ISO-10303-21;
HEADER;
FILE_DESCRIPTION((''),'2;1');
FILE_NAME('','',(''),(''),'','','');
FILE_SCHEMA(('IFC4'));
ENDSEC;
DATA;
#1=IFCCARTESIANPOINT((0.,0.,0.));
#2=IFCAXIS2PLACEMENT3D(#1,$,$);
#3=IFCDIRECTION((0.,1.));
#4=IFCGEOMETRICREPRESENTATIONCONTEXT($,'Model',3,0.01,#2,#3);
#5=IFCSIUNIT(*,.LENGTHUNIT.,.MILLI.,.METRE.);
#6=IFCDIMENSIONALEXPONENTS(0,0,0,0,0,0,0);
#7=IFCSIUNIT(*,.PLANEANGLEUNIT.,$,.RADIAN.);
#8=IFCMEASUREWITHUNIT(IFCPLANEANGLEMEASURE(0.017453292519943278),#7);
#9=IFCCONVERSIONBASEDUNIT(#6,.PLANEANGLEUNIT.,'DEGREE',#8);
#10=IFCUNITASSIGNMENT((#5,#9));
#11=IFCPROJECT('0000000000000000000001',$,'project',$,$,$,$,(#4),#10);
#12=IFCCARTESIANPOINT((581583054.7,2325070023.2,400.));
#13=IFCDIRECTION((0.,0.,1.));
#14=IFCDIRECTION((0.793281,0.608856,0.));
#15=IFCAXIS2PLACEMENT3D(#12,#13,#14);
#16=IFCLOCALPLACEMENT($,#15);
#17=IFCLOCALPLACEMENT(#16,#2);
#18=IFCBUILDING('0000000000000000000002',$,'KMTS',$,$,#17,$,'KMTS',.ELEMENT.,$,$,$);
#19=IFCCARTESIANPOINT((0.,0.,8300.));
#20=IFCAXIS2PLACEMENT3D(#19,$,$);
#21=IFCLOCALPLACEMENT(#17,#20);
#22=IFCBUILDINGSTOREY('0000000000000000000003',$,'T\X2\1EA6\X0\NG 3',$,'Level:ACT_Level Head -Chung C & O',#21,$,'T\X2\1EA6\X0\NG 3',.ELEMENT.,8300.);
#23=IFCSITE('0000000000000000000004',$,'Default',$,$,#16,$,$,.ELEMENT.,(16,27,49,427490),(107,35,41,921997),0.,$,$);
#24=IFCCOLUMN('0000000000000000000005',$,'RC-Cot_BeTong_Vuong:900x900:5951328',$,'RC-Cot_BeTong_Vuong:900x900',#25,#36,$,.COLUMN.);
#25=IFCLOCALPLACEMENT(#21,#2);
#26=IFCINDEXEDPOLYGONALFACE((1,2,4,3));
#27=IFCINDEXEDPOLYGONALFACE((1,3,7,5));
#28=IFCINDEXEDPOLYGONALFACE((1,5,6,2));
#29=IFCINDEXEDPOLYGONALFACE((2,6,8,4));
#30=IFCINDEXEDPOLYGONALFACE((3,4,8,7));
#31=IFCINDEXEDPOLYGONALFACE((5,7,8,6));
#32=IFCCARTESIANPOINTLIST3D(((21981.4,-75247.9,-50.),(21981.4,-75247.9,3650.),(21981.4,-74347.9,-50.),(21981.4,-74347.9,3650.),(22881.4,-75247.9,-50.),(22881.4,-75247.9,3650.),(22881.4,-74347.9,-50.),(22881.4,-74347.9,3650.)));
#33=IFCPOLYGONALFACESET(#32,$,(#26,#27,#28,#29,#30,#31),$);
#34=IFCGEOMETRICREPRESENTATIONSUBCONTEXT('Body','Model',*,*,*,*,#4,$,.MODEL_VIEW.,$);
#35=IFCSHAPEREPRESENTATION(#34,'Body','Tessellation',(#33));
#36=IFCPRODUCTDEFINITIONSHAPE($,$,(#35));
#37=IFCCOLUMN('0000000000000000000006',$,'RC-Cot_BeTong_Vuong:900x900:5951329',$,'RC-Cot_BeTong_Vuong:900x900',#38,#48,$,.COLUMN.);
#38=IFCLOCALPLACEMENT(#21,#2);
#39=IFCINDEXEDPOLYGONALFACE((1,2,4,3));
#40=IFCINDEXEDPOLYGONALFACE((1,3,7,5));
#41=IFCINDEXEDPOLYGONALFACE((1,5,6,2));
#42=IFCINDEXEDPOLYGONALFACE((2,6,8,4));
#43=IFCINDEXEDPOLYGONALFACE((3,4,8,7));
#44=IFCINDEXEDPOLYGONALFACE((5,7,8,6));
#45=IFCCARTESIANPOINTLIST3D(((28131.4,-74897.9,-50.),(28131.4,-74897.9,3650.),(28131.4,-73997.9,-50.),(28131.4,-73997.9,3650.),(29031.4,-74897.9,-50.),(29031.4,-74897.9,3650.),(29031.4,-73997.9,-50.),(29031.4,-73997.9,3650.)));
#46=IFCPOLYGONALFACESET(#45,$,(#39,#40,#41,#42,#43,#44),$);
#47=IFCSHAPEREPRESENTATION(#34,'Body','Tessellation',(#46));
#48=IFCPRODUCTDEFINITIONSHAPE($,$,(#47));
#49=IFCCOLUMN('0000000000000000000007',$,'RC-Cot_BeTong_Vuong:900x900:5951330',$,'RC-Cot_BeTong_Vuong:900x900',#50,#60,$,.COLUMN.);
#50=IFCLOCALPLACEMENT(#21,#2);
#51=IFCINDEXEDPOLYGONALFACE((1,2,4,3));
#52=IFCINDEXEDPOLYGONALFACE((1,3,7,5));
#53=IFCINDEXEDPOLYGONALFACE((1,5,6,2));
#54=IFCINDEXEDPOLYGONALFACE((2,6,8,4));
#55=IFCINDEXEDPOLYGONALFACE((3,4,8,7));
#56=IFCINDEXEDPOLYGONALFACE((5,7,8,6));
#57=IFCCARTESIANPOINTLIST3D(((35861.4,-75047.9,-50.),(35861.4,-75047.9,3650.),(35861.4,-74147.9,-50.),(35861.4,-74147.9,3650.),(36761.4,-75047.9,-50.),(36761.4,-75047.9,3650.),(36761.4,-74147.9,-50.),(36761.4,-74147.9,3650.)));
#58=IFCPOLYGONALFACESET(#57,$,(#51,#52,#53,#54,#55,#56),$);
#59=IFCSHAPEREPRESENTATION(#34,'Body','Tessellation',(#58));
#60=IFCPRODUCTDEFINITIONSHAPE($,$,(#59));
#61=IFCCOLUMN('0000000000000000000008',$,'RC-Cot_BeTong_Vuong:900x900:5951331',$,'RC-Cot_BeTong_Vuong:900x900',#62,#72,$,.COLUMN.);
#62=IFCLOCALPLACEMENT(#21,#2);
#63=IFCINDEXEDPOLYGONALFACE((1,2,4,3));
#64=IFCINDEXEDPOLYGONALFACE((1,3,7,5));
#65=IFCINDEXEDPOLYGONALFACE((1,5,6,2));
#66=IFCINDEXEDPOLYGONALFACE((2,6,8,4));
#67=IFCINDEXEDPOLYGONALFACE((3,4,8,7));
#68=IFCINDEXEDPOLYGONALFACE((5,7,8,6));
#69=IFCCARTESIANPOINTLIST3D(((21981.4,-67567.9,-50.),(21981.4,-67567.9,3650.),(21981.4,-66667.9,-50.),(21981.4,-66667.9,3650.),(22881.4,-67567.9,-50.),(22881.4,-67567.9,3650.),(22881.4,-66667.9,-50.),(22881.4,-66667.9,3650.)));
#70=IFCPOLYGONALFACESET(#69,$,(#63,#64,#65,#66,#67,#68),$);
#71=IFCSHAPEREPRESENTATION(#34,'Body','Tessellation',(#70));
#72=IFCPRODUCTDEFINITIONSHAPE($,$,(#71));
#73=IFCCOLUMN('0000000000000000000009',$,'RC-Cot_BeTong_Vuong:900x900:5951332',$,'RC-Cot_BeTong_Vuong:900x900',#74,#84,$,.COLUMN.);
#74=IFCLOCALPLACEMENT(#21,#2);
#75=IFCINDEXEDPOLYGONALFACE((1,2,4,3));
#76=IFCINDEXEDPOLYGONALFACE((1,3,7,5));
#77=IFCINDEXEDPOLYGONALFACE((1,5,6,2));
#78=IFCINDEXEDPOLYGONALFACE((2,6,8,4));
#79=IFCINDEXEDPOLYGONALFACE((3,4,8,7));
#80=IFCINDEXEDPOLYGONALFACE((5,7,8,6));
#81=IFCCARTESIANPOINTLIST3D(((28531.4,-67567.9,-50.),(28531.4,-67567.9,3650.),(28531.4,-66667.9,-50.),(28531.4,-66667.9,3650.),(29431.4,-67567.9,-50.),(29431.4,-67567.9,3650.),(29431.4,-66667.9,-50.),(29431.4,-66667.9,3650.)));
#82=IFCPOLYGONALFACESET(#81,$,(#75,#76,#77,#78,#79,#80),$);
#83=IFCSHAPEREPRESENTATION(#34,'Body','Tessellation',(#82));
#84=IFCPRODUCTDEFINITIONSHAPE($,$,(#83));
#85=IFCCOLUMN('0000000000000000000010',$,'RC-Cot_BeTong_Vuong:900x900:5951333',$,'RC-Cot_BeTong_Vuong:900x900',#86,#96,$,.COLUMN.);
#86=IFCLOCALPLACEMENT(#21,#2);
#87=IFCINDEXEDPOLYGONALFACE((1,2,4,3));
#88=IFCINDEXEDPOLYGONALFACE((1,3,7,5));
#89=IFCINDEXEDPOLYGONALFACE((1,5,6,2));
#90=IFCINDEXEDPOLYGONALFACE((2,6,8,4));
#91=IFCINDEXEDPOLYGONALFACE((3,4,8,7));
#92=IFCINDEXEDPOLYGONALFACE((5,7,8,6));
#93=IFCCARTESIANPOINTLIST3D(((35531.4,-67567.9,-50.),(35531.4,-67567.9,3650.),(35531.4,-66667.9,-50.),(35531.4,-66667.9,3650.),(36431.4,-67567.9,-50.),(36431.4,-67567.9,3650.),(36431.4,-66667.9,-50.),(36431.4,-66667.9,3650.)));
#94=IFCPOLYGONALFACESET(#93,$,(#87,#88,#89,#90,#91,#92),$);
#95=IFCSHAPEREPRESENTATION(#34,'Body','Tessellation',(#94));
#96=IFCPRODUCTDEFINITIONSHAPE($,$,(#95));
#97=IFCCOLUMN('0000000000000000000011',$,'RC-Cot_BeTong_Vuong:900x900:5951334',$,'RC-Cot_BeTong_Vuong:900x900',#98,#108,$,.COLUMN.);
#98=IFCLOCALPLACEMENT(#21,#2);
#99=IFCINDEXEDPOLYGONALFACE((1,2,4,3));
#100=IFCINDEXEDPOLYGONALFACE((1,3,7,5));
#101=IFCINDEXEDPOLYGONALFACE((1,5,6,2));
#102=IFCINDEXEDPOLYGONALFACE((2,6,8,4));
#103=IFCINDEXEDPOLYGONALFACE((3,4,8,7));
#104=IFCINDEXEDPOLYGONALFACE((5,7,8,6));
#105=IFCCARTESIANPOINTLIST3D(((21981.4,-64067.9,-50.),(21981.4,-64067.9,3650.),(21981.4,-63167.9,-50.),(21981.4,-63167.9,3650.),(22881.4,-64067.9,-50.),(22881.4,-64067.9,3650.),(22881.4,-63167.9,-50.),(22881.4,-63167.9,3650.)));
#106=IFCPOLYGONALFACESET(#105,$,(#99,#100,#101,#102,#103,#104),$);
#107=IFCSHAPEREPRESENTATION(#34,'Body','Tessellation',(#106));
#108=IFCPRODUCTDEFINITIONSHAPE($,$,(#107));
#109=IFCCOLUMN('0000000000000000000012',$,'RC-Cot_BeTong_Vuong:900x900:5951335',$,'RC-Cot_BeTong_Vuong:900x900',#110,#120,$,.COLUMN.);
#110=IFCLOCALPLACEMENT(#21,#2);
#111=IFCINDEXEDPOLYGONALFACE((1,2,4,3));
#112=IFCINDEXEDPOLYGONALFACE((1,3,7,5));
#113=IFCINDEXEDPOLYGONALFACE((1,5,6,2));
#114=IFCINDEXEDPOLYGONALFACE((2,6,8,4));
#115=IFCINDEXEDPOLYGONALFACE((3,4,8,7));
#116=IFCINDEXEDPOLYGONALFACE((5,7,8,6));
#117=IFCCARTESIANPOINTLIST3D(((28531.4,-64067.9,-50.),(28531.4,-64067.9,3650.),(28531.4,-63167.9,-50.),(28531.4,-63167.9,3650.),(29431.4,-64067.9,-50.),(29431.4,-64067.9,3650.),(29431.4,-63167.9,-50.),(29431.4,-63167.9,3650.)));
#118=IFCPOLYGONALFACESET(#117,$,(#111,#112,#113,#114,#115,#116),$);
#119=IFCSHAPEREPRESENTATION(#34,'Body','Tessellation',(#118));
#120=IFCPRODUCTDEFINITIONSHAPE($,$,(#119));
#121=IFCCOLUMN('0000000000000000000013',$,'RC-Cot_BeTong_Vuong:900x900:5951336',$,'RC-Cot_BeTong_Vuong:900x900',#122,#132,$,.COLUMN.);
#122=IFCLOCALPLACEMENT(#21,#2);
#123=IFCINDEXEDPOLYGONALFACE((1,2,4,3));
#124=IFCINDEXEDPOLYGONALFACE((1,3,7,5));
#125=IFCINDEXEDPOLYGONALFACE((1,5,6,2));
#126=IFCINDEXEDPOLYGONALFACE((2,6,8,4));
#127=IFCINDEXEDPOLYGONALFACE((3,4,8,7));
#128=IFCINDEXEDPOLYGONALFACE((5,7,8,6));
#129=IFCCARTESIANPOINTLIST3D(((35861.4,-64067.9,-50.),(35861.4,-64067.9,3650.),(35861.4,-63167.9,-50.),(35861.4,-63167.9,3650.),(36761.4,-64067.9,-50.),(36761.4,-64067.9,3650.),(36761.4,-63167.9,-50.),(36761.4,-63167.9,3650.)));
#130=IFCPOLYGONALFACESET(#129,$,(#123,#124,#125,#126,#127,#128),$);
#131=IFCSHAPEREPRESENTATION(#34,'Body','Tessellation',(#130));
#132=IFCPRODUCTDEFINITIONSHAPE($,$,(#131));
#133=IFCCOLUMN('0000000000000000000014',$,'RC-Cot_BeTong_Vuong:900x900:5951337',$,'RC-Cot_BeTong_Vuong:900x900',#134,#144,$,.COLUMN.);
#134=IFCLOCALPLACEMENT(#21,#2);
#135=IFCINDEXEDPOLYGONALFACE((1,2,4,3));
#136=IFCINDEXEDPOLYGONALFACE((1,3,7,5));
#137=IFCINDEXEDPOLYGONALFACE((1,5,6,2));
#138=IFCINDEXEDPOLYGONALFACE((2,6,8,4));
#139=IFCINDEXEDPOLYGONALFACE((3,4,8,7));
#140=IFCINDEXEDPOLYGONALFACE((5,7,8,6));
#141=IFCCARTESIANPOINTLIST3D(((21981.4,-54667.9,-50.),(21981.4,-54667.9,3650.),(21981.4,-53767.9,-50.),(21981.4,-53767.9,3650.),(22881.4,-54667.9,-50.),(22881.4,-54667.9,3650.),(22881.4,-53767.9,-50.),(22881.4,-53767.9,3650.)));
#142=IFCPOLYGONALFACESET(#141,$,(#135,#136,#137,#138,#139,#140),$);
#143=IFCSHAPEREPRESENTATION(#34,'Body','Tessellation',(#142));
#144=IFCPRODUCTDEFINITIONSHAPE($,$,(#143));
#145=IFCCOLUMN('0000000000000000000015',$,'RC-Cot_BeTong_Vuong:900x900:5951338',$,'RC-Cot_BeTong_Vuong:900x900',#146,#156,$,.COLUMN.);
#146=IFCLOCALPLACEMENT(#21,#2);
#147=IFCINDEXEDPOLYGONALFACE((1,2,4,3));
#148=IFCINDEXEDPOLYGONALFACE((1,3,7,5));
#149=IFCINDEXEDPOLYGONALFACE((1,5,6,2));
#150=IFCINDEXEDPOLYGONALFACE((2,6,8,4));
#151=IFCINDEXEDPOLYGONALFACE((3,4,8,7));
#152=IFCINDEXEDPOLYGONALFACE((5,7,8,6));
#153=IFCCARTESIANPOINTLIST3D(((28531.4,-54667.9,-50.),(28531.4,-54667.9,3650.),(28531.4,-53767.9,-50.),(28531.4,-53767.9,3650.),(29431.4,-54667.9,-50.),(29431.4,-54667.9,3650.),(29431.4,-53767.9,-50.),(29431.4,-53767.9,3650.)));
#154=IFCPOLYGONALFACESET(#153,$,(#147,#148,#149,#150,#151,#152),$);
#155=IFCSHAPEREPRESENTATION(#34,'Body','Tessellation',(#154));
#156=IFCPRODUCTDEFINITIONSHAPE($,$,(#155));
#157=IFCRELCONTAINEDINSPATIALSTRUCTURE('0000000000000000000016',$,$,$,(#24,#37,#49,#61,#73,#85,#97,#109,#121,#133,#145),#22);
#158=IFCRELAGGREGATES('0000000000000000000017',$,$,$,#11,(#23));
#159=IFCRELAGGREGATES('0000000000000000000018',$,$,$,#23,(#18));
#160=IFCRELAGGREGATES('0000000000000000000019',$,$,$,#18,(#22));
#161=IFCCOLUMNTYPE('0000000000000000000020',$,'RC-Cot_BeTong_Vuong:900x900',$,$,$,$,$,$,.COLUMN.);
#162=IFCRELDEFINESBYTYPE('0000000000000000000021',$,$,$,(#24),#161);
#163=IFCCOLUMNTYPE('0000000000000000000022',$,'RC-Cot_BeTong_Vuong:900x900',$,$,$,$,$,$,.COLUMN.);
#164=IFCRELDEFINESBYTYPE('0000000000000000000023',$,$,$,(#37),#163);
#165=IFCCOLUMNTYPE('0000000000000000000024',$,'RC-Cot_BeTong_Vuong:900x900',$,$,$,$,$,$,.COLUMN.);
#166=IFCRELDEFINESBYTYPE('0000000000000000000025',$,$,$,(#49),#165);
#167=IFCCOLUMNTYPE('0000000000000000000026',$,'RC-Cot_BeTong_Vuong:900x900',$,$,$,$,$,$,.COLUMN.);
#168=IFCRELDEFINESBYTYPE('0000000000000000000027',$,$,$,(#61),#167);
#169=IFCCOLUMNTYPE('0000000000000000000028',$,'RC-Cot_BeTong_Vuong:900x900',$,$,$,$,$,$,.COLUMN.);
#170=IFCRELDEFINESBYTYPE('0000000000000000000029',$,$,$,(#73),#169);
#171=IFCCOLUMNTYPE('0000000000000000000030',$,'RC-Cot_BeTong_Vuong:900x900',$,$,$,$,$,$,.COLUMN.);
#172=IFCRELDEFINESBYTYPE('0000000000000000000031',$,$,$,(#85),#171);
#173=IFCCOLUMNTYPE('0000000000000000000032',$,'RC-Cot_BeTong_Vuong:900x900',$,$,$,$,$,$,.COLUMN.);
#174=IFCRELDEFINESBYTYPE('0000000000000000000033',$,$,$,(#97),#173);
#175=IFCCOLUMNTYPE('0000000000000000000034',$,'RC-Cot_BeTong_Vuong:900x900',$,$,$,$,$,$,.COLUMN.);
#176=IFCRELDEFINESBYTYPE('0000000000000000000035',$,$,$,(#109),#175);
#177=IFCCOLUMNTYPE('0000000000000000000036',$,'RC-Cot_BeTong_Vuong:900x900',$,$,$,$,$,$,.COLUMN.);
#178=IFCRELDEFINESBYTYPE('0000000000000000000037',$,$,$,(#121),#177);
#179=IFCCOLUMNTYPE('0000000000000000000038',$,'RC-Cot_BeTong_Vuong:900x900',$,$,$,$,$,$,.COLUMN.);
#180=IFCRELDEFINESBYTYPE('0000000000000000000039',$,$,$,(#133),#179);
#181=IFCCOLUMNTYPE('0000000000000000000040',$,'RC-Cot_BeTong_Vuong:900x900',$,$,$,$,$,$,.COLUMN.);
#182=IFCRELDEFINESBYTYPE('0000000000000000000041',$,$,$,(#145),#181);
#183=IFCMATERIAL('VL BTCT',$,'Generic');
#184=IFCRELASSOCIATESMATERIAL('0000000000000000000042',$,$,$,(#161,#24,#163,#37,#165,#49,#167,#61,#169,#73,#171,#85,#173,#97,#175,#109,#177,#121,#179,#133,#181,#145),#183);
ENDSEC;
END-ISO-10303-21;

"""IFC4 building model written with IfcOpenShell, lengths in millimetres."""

from ifc_helpers import new_model, entity, si_unit, converted_unit, direction, frame, origin, place, context, subcontext, project, spatial, indexed_curve, outline, extrude, source, transform, mapped, material, type_object, type_shapes, element, save


model = new_model("IFC4")

# Units and contexts
model_context = context("Model", 3, precision=0.01, world=origin(), true_north=direction((0.0, 1.0)))
body_context = subcontext(model_context, "Body", "Model", "MODEL_VIEW")
ifc_project = project(units=[si_unit("LENGTHUNIT", "METRE", prefix="MILLI"), converted_unit("PLANEANGLEUNIT", "DEGREE", entity("IfcPlaneAngleMeasure", 0.017453292519943278), si_unit("PLANEANGLEUNIT", "RADIAN"), dimensions=[0, 0, 0, 0, 0, 0, 0])], contexts=[model_context])

# Site, building, storey
site_placement = place(None, frame((581583054.7, 2325070023.2, 400.0), z_axis=(0.0, 0.0, 1.0), x_axis=(0.793281, 0.608856, 0.0)))
site = spatial("IfcSite", under=ifc_project, at=site_placement, Name="Default", CompositionType="ELEMENT", RefLatitude=(16, 27, 49, 427490), RefLongitude=(107, 35, 41, 921997), RefElevation=0.0)
building_placement = place(site_placement, origin())
building = spatial("IfcBuilding", under=site, at=building_placement, Name="KMTS", LongName="KMTS", CompositionType="ELEMENT")
storey_placement = place(building_placement, frame((0.0, 0.0, 8300.0)))
storey = spatial("IfcBuildingStorey", under=building, at=storey_placement, Name="TẦNG 3", ObjectType="Level:ACT_Level Head -Chung C & O", LongName="TẦNG 3", CompositionType="ELEMENT", Elevation=8300.0)

# Columns
ifc_material_1 = material(Name="VL BTCT", Category="Generic")
column_type_1 = type_object("IfcColumnType", Name="RC-Cot_BeTong_Vuong:900x900", PredefinedType="COLUMN", material=ifc_material_1)
shared_shape_1 = source(origin(), body_context, "Body", "SweptSolid", [
    extrude(outline(indexed_curve([(-450.0, -450.0), (450.0, -450.0), (450.0, 450.0), (-450.0, 450.0), (-450.0, -450.0)], self_intersect=False)), frame((22431.4, -74797.9, 8250.0), z_axis=(0.0, 0.0, 1.0), x_axis=(-1.0, 0.0, 0.0)), (0.0, 0.0, 1.0), 3700.0),
])
type_shapes(column_type_1, [shared_shape_1])
column_1_placement = place(storey_placement, frame((0.0, 0.0, -8300.0)))
element("IfcColumn", 1, at=column_1_placement, inside=storey, type_object=column_type_1, material=ifc_material_1, Name="RC-Cot_BeTong_Vuong:900x900:5951328", ObjectType="RC-Cot_BeTong_Vuong:900x900", PredefinedType="COLUMN", context=body_context, shape_type="MappedRepresentation", body=[
    mapped(shared_shape_1, transform((0.0, 0.0, 0.0), scale=1.0)),
])
column_type_2 = type_object("IfcColumnType", Name="RC-Cot_BeTong_Vuong:900x900", PredefinedType="COLUMN", material=ifc_material_1)
shared_shape_2 = source(origin(), body_context, "Body", "SweptSolid", [
    extrude(outline(indexed_curve([(-450.0, -450.0), (450.0, -450.0), (450.0, 450.0), (-450.0, 450.0), (-450.0, -450.0)], self_intersect=False)), frame((28581.4, -74447.9, 8250.0), z_axis=(0.0, 0.0, 1.0), x_axis=(-1.0, 0.0, 0.0)), (0.0, 0.0, 1.0), 3700.0),
])
type_shapes(column_type_2, [shared_shape_2])
column_2_placement = place(storey_placement, frame((0.0, 0.0, -8300.0)))
element("IfcColumn", 2, at=column_2_placement, inside=storey, type_object=column_type_2, material=ifc_material_1, Name="RC-Cot_BeTong_Vuong:900x900:5951329", ObjectType="RC-Cot_BeTong_Vuong:900x900", PredefinedType="COLUMN", context=body_context, shape_type="MappedRepresentation", body=[
    mapped(shared_shape_2, transform((0.0, 0.0, 0.0), scale=1.0)),
])
column_type_3 = type_object("IfcColumnType", Name="RC-Cot_BeTong_Vuong:900x900", PredefinedType="COLUMN", material=ifc_material_1)
shared_shape_3 = source(origin(), body_context, "Body", "SweptSolid", [
    extrude(outline(indexed_curve([(-450.0, -450.0), (450.0, -450.0), (450.0, 450.0), (-450.0, 450.0), (-450.0, -450.0)], self_intersect=False)), frame((36311.4, -74597.9, 8250.0), z_axis=(0.0, 0.0, 1.0), x_axis=(-1.0, 0.0, 0.0)), (0.0, 0.0, 1.0), 3700.0),
])
type_shapes(column_type_3, [shared_shape_3])
column_3_placement = place(storey_placement, frame((0.0, 0.0, -8300.0)))
element("IfcColumn", 3, at=column_3_placement, inside=storey, type_object=column_type_3, material=ifc_material_1, Name="RC-Cot_BeTong_Vuong:900x900:5951330", ObjectType="RC-Cot_BeTong_Vuong:900x900", PredefinedType="COLUMN", context=body_context, shape_type="MappedRepresentation", body=[
    mapped(shared_shape_3, transform((0.0, 0.0, 0.0), scale=1.0)),
])
column_type_4 = type_object("IfcColumnType", Name="RC-Cot_BeTong_Vuong:900x900", PredefinedType="COLUMN", material=ifc_material_1)
shared_shape_4 = source(origin(), body_context, "Body", "SweptSolid", [
    extrude(outline(indexed_curve([(-450.0, -450.0), (450.0, -450.0), (450.0, 450.0), (-450.0, 450.0), (-450.0, -450.0)], self_intersect=False)), frame((22431.4, -67117.9, 8250.0), z_axis=(0.0, 0.0, 1.0), x_axis=(-1.0, 0.0, 0.0)), (0.0, 0.0, 1.0), 3700.0),
])
type_shapes(column_type_4, [shared_shape_4])
column_4_placement = place(storey_placement, frame((0.0, 0.0, -8300.0)))
element("IfcColumn", 4, at=column_4_placement, inside=storey, type_object=column_type_4, material=ifc_material_1, Name="RC-Cot_BeTong_Vuong:900x900:5951331", ObjectType="RC-Cot_BeTong_Vuong:900x900", PredefinedType="COLUMN", context=body_context, shape_type="MappedRepresentation", body=[
    mapped(shared_shape_4, transform((0.0, 0.0, 0.0), scale=1.0)),
])
column_type_5 = type_object("IfcColumnType", Name="RC-Cot_BeTong_Vuong:900x900", PredefinedType="COLUMN", material=ifc_material_1)
shared_shape_5 = source(origin(), body_context, "Body", "SweptSolid", [
    extrude(outline(indexed_curve([(-450.0, -450.0), (450.0, -450.0), (450.0, 450.0), (-450.0, 450.0), (-450.0, -450.0)], self_intersect=False)), frame((28981.4, -67117.9, 8250.0), z_axis=(0.0, 0.0, 1.0), x_axis=(-1.0, 0.0, 0.0)), (0.0, 0.0, 1.0), 3700.0),
])
type_shapes(column_type_5, [shared_shape_5])
column_5_placement = place(storey_placement, frame((0.0, 0.0, -8300.0)))
element("IfcColumn", 5, at=column_5_placement, inside=storey, type_object=column_type_5, material=ifc_material_1, Name="RC-Cot_BeTong_Vuong:900x900:5951332", ObjectType="RC-Cot_BeTong_Vuong:900x900", PredefinedType="COLUMN", context=body_context, shape_type="MappedRepresentation", body=[
    mapped(shared_shape_5, transform((0.0, 0.0, 0.0), scale=1.0)),
])
column_type_6 = type_object("IfcColumnType", Name="RC-Cot_BeTong_Vuong:900x900", PredefinedType="COLUMN", material=ifc_material_1)
shared_shape_6 = source(origin(), body_context, "Body", "SweptSolid", [
    extrude(outline(indexed_curve([(-450.0, -450.0), (450.0, -450.0), (450.0, 450.0), (-450.0, 450.0), (-450.0, -450.0)], self_intersect=False)), frame((35981.4, -67117.9, 8250.0), z_axis=(0.0, 0.0, 1.0), x_axis=(-1.0, 0.0, 0.0)), (0.0, 0.0, 1.0), 3700.0),
])
type_shapes(column_type_6, [shared_shape_6])
column_6_placement = place(storey_placement, frame((0.0, 0.0, -8300.0)))
element("IfcColumn", 6, at=column_6_placement, inside=storey, type_object=column_type_6, material=ifc_material_1, Name="RC-Cot_BeTong_Vuong:900x900:5951333", ObjectType="RC-Cot_BeTong_Vuong:900x900", PredefinedType="COLUMN", context=body_context, shape_type="MappedRepresentation", body=[
    mapped(shared_shape_6, transform((0.0, 0.0, 0.0), scale=1.0)),
])
column_type_7 = type_object("IfcColumnType", Name="RC-Cot_BeTong_Vuong:900x900", PredefinedType="COLUMN", material=ifc_material_1)
shared_shape_7 = source(origin(), body_context, "Body", "SweptSolid", [
    extrude(outline(indexed_curve([(-450.0, -450.0), (450.0, -450.0), (450.0, 450.0), (-450.0, 450.0), (-450.0, -450.0)], self_intersect=False)), frame((22431.4, -63617.9, 8250.0), z_axis=(0.0, 0.0, 1.0), x_axis=(-1.0, 0.0, 0.0)), (0.0, 0.0, 1.0), 3700.0),
])
type_shapes(column_type_7, [shared_shape_7])
column_7_placement = place(storey_placement, frame((0.0, 0.0, -8300.0)))
element("IfcColumn", 7, at=column_7_placement, inside=storey, type_object=column_type_7, material=ifc_material_1, Name="RC-Cot_BeTong_Vuong:900x900:5951334", ObjectType="RC-Cot_BeTong_Vuong:900x900", PredefinedType="COLUMN", context=body_context, shape_type="MappedRepresentation", body=[
    mapped(shared_shape_7, transform((0.0, 0.0, 0.0), scale=1.0)),
])
column_type_8 = type_object("IfcColumnType", Name="RC-Cot_BeTong_Vuong:900x900", PredefinedType="COLUMN", material=ifc_material_1)
shared_shape_8 = source(origin(), body_context, "Body", "SweptSolid", [
    extrude(outline(indexed_curve([(-450.0, -450.0), (450.0, -450.0), (450.0, 450.0), (-450.0, 450.0), (-450.0, -450.0)], self_intersect=False)), frame((28981.4, -63617.9, 8250.0), z_axis=(0.0, 0.0, 1.0), x_axis=(-1.0, 0.0, 0.0)), (0.0, 0.0, 1.0), 3700.0),
])
type_shapes(column_type_8, [shared_shape_8])
column_8_placement = place(storey_placement, frame((0.0, 0.0, -8300.0)))
element("IfcColumn", 8, at=column_8_placement, inside=storey, type_object=column_type_8, material=ifc_material_1, Name="RC-Cot_BeTong_Vuong:900x900:5951335", ObjectType="RC-Cot_BeTong_Vuong:900x900", PredefinedType="COLUMN", context=body_context, shape_type="MappedRepresentation", body=[
    mapped(shared_shape_8, transform((0.0, 0.0, 0.0), scale=1.0)),
])
column_type_9 = type_object("IfcColumnType", Name="RC-Cot_BeTong_Vuong:900x900", PredefinedType="COLUMN", material=ifc_material_1)
shared_shape_9 = source(origin(), body_context, "Body", "SweptSolid", [
    extrude(outline(indexed_curve([(-450.0, -450.0), (450.0, -450.0), (450.0, 450.0), (-450.0, 450.0), (-450.0, -450.0)], self_intersect=False)), frame((36311.4, -63617.9, 8250.0), z_axis=(0.0, 0.0, 1.0), x_axis=(-1.0, 0.0, 0.0)), (0.0, 0.0, 1.0), 3700.0),
])
type_shapes(column_type_9, [shared_shape_9])
column_9_placement = place(storey_placement, frame((0.0, 0.0, -8300.0)))
element("IfcColumn", 9, at=column_9_placement, inside=storey, type_object=column_type_9, material=ifc_material_1, Name="RC-Cot_BeTong_Vuong:900x900:5951336", ObjectType="RC-Cot_BeTong_Vuong:900x900", PredefinedType="COLUMN", context=body_context, shape_type="MappedRepresentation", body=[
    mapped(shared_shape_9, transform((0.0, 0.0, 0.0), scale=1.0)),
])
column_type_10 = type_object("IfcColumnType", Name="RC-Cot_BeTong_Vuong:900x900", PredefinedType="COLUMN", material=ifc_material_1)
shared_shape_10 = source(origin(), body_context, "Body", "SweptSolid", [
    extrude(outline(indexed_curve([(-450.0, -450.0), (450.0, -450.0), (450.0, 450.0), (-450.0, 450.0), (-450.0, -450.0)], self_intersect=False)), frame((22431.4, -54217.9, 8250.0), z_axis=(0.0, 0.0, 1.0), x_axis=(-1.0, 0.0, 0.0)), (0.0, 0.0, 1.0), 3700.0),
])
type_shapes(column_type_10, [shared_shape_10])
column_10_placement = place(storey_placement, frame((0.0, 0.0, -8300.0)))
element("IfcColumn", 10, at=column_10_placement, inside=storey, type_object=column_type_10, material=ifc_material_1, Name="RC-Cot_BeTong_Vuong:900x900:5951337", ObjectType="RC-Cot_BeTong_Vuong:900x900", PredefinedType="COLUMN", context=body_context, shape_type="MappedRepresentation", body=[
    mapped(shared_shape_10, transform((0.0, 0.0, 0.0), scale=1.0)),
])
column_type_11 = type_object("IfcColumnType", Name="RC-Cot_BeTong_Vuong:900x900", PredefinedType="COLUMN", material=ifc_material_1)
shared_shape_11 = source(origin(), body_context, "Body", "SweptSolid", [
    extrude(outline(indexed_curve([(-450.0, -450.0), (450.0, -450.0), (450.0, 450.0), (-450.0, 450.0), (-450.0, -450.0)], self_intersect=False)), frame((28981.4, -54217.9, 8250.0), z_axis=(0.0, 0.0, 1.0), x_axis=(-1.0, 0.0, 0.0)), (0.0, 0.0, 1.0), 3700.0),
])
type_shapes(column_type_11, [shared_shape_11])
column_11_placement = place(storey_placement, frame((0.0, 0.0, -8300.0)))
element("IfcColumn", 11, at=column_11_placement, inside=storey, type_object=column_type_11, material=ifc_material_1, Name="RC-Cot_BeTong_Vuong:900x900:5951338", ObjectType="RC-Cot_BeTong_Vuong:900x900", PredefinedType="COLUMN", context=body_context, shape_type="MappedRepresentation", body=[
    mapped(shared_shape_11, transform((0.0, 0.0, 0.0), scale=1.0)),
])

save(model, "model.ifc")
